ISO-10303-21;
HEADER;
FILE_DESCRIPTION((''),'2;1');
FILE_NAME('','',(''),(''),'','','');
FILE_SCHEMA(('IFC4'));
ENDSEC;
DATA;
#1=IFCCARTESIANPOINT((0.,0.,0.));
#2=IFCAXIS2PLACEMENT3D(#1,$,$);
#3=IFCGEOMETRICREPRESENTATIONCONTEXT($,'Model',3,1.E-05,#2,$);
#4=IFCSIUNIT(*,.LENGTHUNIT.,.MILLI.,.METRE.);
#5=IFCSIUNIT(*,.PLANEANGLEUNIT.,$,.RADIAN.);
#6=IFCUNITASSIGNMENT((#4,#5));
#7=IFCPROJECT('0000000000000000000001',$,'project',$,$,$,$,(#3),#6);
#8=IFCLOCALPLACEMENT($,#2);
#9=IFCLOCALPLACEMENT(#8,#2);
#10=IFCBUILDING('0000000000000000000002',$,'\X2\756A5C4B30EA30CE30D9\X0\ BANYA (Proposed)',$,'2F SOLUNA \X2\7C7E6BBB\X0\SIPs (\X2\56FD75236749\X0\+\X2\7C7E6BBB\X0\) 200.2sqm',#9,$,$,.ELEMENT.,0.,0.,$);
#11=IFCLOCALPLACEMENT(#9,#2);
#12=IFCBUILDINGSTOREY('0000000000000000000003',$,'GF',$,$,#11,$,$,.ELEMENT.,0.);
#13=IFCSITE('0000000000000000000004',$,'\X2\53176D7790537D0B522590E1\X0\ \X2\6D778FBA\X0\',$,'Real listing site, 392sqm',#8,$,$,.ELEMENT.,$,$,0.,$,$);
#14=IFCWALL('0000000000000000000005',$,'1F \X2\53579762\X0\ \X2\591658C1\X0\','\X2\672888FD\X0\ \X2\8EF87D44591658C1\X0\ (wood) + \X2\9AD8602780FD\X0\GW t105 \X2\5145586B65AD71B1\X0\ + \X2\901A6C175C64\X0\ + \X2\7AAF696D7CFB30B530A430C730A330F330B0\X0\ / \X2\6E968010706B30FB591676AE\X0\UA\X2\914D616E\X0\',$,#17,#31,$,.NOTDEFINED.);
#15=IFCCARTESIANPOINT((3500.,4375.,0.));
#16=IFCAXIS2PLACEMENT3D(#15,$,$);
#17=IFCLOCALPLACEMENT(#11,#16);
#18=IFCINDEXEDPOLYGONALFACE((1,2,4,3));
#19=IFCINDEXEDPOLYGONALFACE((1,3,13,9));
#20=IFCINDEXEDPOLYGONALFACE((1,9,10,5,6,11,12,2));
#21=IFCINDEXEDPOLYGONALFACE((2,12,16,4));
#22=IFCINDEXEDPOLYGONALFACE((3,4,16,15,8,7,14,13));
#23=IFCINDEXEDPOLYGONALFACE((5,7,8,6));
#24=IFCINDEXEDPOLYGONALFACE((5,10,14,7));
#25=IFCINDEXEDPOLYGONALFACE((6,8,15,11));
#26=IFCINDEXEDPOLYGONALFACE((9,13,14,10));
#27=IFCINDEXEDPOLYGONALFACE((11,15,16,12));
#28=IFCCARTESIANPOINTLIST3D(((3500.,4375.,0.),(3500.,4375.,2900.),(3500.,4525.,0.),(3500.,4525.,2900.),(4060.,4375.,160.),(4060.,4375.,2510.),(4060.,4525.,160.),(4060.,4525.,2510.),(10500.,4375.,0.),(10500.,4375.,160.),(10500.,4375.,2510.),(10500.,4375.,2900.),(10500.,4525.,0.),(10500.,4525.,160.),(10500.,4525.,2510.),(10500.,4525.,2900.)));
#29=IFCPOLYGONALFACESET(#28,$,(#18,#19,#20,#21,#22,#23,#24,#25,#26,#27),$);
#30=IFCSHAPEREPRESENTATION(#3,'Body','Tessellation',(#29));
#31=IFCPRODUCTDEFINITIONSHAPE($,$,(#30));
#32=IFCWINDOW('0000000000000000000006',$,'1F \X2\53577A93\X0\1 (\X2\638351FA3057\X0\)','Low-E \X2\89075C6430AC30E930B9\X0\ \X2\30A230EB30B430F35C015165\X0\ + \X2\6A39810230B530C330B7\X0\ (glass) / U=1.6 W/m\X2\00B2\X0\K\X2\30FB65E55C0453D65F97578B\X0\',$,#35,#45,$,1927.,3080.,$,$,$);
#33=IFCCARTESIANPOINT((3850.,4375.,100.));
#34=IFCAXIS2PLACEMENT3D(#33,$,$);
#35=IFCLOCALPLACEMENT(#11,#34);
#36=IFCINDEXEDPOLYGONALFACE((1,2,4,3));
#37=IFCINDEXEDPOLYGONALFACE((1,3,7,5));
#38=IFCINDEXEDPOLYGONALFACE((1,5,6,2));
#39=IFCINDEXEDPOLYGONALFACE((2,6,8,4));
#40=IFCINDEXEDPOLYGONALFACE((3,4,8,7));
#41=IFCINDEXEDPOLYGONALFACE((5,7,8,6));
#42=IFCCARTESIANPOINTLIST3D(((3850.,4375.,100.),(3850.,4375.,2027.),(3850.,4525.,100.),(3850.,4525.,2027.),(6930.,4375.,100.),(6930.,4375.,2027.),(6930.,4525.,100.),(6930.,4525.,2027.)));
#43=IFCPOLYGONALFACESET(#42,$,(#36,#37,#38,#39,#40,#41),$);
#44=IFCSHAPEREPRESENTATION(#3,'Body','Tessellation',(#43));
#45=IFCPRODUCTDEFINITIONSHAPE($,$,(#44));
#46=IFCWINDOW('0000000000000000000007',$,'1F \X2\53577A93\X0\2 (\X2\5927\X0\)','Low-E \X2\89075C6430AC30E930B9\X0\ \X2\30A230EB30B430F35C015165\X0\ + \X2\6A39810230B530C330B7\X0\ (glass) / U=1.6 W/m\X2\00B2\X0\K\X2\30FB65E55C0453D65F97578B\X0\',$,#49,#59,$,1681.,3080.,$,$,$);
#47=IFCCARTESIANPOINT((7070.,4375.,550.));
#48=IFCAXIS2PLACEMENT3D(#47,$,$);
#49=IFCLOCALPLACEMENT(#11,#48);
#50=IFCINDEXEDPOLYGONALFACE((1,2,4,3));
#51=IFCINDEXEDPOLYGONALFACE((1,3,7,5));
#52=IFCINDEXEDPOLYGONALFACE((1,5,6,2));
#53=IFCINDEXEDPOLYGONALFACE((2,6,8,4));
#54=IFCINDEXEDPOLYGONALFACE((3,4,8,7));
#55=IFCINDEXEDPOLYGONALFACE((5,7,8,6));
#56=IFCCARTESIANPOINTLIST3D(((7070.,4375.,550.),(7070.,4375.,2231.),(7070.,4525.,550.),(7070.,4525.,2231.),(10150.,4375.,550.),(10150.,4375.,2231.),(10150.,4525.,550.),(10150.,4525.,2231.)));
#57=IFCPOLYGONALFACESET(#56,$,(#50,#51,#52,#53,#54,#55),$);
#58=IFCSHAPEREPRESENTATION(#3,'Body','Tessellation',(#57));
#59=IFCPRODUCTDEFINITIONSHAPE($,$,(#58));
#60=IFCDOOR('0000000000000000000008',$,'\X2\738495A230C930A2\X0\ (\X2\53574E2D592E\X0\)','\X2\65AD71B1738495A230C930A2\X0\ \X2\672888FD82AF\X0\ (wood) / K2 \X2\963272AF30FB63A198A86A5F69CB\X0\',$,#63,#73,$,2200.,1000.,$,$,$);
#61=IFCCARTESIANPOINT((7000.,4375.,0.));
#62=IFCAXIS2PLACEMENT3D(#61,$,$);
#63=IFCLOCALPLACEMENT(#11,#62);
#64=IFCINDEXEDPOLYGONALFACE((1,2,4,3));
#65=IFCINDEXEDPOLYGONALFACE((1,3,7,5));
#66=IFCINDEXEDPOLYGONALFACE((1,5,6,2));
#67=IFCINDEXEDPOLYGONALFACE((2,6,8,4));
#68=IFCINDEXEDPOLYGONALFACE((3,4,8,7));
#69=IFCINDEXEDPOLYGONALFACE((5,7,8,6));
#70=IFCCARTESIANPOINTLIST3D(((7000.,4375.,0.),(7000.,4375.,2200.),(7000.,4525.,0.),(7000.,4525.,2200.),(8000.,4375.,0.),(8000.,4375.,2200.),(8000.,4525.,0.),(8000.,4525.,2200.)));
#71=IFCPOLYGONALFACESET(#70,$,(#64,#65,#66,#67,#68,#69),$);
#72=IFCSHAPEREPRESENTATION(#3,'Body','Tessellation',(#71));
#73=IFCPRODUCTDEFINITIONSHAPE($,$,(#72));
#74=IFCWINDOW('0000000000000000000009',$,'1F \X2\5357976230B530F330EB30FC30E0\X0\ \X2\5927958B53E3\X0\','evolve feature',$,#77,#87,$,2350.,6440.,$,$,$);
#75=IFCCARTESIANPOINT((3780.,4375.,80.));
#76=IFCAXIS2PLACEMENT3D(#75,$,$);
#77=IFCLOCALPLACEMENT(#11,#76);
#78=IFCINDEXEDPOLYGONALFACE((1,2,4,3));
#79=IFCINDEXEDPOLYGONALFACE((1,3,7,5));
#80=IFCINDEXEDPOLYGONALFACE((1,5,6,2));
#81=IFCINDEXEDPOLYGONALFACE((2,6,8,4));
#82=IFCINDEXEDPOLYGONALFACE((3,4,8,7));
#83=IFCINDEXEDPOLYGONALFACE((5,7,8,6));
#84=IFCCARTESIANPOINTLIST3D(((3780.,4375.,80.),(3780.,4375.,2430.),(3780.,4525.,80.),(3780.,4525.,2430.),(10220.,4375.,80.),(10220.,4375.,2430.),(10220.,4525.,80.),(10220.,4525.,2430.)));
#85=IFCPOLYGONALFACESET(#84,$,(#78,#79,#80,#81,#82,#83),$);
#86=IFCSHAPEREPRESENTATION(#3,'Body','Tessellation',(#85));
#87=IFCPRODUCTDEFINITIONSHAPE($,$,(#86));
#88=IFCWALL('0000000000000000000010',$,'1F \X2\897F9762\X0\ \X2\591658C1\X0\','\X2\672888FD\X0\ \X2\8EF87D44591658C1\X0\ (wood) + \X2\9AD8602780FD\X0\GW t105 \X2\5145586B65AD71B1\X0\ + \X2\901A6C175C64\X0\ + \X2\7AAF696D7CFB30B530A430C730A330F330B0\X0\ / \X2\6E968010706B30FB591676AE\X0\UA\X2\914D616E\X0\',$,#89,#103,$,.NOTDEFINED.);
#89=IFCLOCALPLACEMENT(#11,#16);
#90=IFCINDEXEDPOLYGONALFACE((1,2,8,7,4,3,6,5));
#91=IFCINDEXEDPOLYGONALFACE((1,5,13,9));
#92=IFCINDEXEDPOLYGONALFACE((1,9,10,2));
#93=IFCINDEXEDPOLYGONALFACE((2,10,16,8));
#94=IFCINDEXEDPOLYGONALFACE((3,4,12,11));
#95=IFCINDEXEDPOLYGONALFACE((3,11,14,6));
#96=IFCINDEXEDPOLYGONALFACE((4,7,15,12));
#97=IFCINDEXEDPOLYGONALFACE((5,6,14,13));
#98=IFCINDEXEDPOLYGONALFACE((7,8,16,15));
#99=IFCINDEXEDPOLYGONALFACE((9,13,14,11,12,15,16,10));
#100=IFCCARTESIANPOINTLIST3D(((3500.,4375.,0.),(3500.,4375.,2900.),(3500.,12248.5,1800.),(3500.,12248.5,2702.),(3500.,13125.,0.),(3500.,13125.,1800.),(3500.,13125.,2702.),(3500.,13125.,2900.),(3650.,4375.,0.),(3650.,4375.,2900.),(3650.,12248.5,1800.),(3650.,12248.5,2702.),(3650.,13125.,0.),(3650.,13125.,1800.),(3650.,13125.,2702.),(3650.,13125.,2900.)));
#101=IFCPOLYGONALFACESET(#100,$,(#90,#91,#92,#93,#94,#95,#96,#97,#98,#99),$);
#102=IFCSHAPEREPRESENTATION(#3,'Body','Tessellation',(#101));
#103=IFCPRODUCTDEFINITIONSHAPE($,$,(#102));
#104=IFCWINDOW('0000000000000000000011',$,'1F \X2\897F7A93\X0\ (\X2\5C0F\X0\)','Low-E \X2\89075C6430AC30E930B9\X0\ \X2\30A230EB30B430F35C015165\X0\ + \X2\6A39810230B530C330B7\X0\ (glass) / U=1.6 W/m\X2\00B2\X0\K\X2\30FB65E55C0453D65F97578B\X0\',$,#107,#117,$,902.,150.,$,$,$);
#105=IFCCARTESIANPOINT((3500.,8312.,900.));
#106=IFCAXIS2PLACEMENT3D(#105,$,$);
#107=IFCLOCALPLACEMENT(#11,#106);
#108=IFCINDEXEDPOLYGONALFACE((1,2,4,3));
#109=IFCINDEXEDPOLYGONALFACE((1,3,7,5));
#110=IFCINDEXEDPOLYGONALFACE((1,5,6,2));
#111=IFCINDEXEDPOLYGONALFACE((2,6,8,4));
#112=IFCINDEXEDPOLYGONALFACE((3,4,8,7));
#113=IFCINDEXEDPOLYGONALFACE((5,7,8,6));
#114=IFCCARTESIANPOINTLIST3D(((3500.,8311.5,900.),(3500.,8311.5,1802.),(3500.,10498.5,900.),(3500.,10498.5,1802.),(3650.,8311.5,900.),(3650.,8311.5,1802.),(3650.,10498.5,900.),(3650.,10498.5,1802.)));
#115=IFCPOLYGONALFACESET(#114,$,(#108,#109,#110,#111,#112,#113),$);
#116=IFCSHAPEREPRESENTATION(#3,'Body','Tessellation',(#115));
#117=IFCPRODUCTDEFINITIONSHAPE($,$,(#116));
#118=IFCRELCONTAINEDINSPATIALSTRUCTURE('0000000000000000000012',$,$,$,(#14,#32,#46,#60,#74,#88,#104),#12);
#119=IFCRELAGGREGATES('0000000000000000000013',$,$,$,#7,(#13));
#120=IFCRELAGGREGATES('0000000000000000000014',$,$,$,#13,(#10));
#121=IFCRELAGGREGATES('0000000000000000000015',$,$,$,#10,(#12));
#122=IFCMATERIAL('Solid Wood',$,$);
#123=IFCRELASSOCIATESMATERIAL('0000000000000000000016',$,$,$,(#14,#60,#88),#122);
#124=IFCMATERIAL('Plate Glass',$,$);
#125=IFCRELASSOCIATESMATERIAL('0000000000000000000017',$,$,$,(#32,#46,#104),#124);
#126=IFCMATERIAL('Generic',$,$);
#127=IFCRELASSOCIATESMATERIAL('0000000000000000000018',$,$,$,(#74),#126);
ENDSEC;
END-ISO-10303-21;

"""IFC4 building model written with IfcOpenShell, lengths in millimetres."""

from ifc_helpers import new_model, si_unit, frame, frame_2d, origin, place, context, project, spatial, rectangle, extrude, material, element, fill, save


model = new_model("IFC4")

# Units and contexts
model_context = context("Model", 3, precision=1e-05, world=origin())
ifc_project = project(units=[si_unit("LENGTHUNIT", "METRE", prefix="MILLI"), si_unit("PLANEANGLEUNIT", "RADIAN")], contexts=[model_context])

# Site, building, storey
site_placement = place(None, origin())
site = spatial("IfcSite", under=ifc_project, at=site_placement, Name="北海道紋別郡 海辺", ObjectType="Real listing site, 392sqm", CompositionType="ELEMENT", RefElevation=0.0)
building_placement = place(site_placement, origin())
building = spatial("IfcBuilding", under=site, at=building_placement, Name="番屋リノベ BANYA (Proposed)", ObjectType="2F SOLUNA 籾殻SIPs (国産杉+籾殻) 200.2sqm", CompositionType="ELEMENT", ElevationOfRefHeight=0.0, ElevationOfTerrain=0.0)
storey_placement = place(building_placement, origin())
storey = spatial("IfcBuildingStorey", under=building, at=storey_placement, Name="GF", CompositionType="ELEMENT", Elevation=0.0)

# Shared definitions
ifc_material_1 = material(Name="Solid Wood")

# Wall, openings, windows, door
wall_1_placement = place(storey_placement, frame((3500.0, 4375.0, 0.0)))
wall_1 = element("IfcWall", 1, at=wall_1_placement, inside=storey, material=ifc_material_1, Name="1F 南面 外壁", Description="木製 軸組外壁 (wood) + 高性能GW t105 充填断熱 + 通気層 + 窯業系サイディング / 準耐火・外皮UA配慮", PredefinedType="NOTDEFINED", context=model_context, shape_type="SweptSolid", body=[
    extrude(rectangle(XDim=7000.0, YDim=150.0, at=frame_2d((3500.0, 75.0))), frame((3500.0, 4375.0, 0.0)), (0.0, 0.0, 1.0), 2900.0),
])
opening_1_placement = place(storey_placement, frame((3850.0, 4375.0, 100.0)))
opening_1 = element("IfcOpeningElement", 2, at=opening_1_placement, cuts=wall_1, PredefinedType="NOTDEFINED", context=model_context, shape_type="SweptSolid", body=[
    extrude(rectangle(XDim=3080.0, YDim=150.0, at=frame_2d((1540.0, 75.0))), frame((3850.0, 4375.0, 100.0)), (0.0, 0.0, 1.0), 1927.0),
])
opening_2_placement = place(storey_placement, frame((7070.0, 4375.0, 550.0)))
opening_2 = element("IfcOpeningElement", 3, at=opening_2_placement, cuts=wall_1, PredefinedType="NOTDEFINED", context=model_context, shape_type="SweptSolid", body=[
    extrude(rectangle(XDim=3080.0, YDim=150.0, at=frame_2d((1540.0, 75.0))), frame((7070.0, 4375.0, 550.0)), (0.0, 0.0, 1.0), 1681.0),
])
opening_3_placement = place(storey_placement, frame((7000.0, 4375.0, 0.0)))
opening_3 = element("IfcOpeningElement", 4, at=opening_3_placement, cuts=wall_1, PredefinedType="NOTDEFINED", context=model_context, shape_type="SweptSolid", body=[
    extrude(rectangle(XDim=1000.0, YDim=150.0, at=frame_2d((500.0, 75.0))), frame((7000.0, 4375.0, 0.0)), (0.0, 0.0, 1.0), 2200.0),
])
opening_4_placement = place(storey_placement, frame((3780.0, 4375.0, 80.0)))
opening_4 = element("IfcOpeningElement", 5, at=opening_4_placement, cuts=wall_1, PredefinedType="NOTDEFINED", context=model_context, shape_type="SweptSolid", body=[
    extrude(rectangle(XDim=6440.0, YDim=150.0, at=frame_2d((3220.0, 75.0))), frame((3780.0, 4375.0, 80.0)), (0.0, 0.0, 1.0), 2350.0),
])
ifc_material_2 = material(Name="Plate Glass")
window_1_placement = place(storey_placement, frame((3850.0, 4375.0, 100.0)))
window_1 = element("IfcWindow", 6, at=window_1_placement, inside=storey, material=ifc_material_2, Name="1F 南窓1 (掃出し)", Description="Low-E 複層ガラス アルゴン封入 + 樹脂サッシ (glass) / U=1.6 W/m²K・日射取得型", OverallHeight=1927.0, OverallWidth=3080.0, context=model_context, shape_type="SweptSolid", body=[
    extrude(rectangle(XDim=3080.0, YDim=150.0, at=frame_2d((1540.0, 75.0))), frame((3850.0, 4375.0, 100.0)), (0.0, 0.0, 1.0), 1927.0),
])
fill(opening_1, window_1)
window_2_placement = place(storey_placement, frame((7070.0, 4375.0, 550.0)))
window_2 = element("IfcWindow", 7, at=window_2_placement, inside=storey, material=ifc_material_2, Name="1F 南窓2 (大)", Description="Low-E 複層ガラス アルゴン封入 + 樹脂サッシ (glass) / U=1.6 W/m²K・日射取得型", OverallHeight=1681.0, OverallWidth=3080.0, context=model_context, shape_type="SweptSolid", body=[
    extrude(rectangle(XDim=3080.0, YDim=150.0, at=frame_2d((1540.0, 75.0))), frame((7070.0, 4375.0, 550.0)), (0.0, 0.0, 1.0), 1681.0),
])
fill(opening_2, window_2)
door_placement = place(storey_placement, frame((7000.0, 4375.0, 0.0)))
door = element("IfcDoor", 8, at=door_placement, inside=storey, material=ifc_material_1, Name="玄関ドア (南中央)", Description="断熱玄関ドア 木製芯 (wood) / K2 防犯・採風機構", OverallHeight=2200.0, OverallWidth=1000.0, context=model_context, shape_type="SweptSolid", body=[
    extrude(rectangle(XDim=1000.0, YDim=150.0, at=frame_2d((500.0, 75.0))), frame((7000.0, 4375.0, 0.0)), (0.0, 0.0, 1.0), 2200.0),
])
fill(opening_3, door)
ifc_material_3 = material(Name="Generic")
window_3_placement = place(storey_placement, frame((3780.0, 4375.0, 80.0)))
window_3 = element("IfcWindow", 9, at=window_3_placement, inside=storey, material=ifc_material_3, Name="1F 南面サンルーム 大開口", Description="evolve feature", OverallHeight=2350.0, OverallWidth=6440.0, context=model_context, shape_type="SweptSolid", body=[
    extrude(rectangle(XDim=6440.0, YDim=150.0, at=frame_2d((3220.0, 75.0))), frame((3780.0, 4375.0, 80.0)), (0.0, 0.0, 1.0), 2350.0),
])
fill(opening_4, window_3)

# Wall, opening, window
wall_2_placement = place(storey_placement, frame((3500.0, 4375.0, 0.0)))
wall_2 = element("IfcWall", 10, at=wall_2_placement, inside=storey, material=ifc_material_1, Name="1F 西面 外壁", Description="木製 軸組外壁 (wood) + 高性能GW t105 充填断熱 + 通気層 + 窯業系サイディング / 準耐火・外皮UA配慮", PredefinedType="NOTDEFINED", context=model_context, shape_type="SweptSolid", body=[
    extrude(rectangle(XDim=150.0, YDim=8750.0, at=frame_2d((75.0, 4375.0))), frame((3500.0, 4375.0, 0.0)), (0.0, 0.0, 1.0), 2900.0),
])
opening_5_placement = place(storey_placement, frame((3500.0, 8312.0, 900.0)))
opening_5 = element("IfcOpeningElement", 11, at=opening_5_placement, cuts=wall_2, PredefinedType="NOTDEFINED", context=model_context, shape_type="SweptSolid", body=[
    extrude(rectangle(XDim=150.0, YDim=2187.0, at=frame_2d((75.0, 1093.0))), frame((3500.0, 8312.0, 900.0)), (0.0, 0.0, 1.0), 902.0),
])
window_4_placement = place(storey_placement, frame((3500.0, 8312.0, 900.0)))
window_4 = element("IfcWindow", 12, at=window_4_placement, inside=storey, material=ifc_material_2, Name="1F 西窓 (小)", Description="Low-E 複層ガラス アルゴン封入 + 樹脂サッシ (glass) / U=1.6 W/m²K・日射取得型", OverallHeight=902.0, OverallWidth=150.0, context=model_context, shape_type="SweptSolid", body=[
    extrude(rectangle(XDim=150.0, YDim=2187.0, at=frame_2d((75.0, 1093.0))), frame((3500.0, 8312.0, 900.0)), (0.0, 0.0, 1.0), 902.0),
])
fill(opening_5, window_4)

save(model, "model.ifc")
